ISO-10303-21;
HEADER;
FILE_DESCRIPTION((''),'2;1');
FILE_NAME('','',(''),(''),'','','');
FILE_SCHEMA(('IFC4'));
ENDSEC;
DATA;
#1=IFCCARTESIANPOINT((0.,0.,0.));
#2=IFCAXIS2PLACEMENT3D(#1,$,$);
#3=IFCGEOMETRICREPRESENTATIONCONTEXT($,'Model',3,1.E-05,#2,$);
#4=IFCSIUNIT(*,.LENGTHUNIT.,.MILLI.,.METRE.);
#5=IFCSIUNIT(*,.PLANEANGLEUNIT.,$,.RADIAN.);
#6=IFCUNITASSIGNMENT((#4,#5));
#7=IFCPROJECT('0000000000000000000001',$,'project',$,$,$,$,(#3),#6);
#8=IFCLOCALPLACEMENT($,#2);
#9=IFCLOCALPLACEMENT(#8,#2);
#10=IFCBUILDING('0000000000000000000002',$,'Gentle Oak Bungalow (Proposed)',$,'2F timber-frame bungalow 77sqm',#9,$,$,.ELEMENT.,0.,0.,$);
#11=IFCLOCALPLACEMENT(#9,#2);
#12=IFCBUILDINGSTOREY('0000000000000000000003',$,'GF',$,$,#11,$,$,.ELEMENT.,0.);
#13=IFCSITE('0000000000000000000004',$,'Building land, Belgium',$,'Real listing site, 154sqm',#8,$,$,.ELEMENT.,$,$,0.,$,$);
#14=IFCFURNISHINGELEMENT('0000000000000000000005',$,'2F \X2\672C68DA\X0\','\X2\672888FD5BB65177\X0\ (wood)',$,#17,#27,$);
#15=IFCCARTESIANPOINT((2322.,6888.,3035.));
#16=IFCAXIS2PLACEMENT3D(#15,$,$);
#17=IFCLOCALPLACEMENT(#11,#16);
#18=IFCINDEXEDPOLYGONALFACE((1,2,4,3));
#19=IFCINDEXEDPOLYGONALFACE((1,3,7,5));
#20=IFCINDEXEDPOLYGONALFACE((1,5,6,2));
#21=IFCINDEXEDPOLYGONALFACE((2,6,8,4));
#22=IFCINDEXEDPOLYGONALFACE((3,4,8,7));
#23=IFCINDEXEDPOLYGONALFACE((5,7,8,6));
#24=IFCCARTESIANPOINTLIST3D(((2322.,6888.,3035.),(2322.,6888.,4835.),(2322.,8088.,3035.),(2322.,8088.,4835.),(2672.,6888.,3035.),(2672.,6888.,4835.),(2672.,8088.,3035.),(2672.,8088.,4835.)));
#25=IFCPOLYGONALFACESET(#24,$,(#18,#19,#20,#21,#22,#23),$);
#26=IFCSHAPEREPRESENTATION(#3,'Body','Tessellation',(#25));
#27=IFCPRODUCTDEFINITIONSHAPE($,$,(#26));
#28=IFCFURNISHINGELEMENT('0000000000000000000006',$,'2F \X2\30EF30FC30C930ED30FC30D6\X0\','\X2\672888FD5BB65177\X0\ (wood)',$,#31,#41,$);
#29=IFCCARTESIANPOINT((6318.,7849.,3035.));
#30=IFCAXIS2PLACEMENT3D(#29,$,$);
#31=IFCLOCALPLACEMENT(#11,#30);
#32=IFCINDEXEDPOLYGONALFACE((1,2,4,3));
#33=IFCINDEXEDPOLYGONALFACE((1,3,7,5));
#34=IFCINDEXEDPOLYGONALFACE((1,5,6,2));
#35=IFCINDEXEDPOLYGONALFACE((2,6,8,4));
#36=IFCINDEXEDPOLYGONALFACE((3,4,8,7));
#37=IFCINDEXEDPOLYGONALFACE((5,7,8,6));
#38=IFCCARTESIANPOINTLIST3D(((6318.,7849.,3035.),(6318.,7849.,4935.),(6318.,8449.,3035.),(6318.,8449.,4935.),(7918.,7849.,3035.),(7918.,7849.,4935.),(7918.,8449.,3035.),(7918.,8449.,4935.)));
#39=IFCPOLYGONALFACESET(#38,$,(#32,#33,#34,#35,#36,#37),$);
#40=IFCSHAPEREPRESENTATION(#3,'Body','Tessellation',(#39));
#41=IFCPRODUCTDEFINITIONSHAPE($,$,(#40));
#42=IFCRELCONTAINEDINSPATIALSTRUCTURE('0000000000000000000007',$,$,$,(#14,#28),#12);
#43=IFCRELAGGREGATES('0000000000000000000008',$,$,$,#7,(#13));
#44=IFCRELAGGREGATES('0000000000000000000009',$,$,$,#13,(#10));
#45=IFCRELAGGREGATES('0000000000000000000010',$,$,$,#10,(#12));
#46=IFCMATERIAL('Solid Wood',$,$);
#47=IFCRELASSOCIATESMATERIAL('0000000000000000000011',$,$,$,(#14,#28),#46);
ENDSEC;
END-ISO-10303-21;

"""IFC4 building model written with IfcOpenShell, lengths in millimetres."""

from ifc_helpers import new_model, si_unit, frame, frame_2d, origin, place, context, project, spatial, rectangle, extrude, material, element, save


model = new_model("IFC4")

# Units and contexts
model_context = context("Model", 3, precision=1e-05, world=origin())
ifc_project = project(units=[si_unit("LENGTHUNIT", "METRE", prefix="MILLI"), si_unit("PLANEANGLEUNIT", "RADIAN")], contexts=[model_context])

# Site, building, storey
site_placement = place(None, origin())
site = spatial("IfcSite", under=ifc_project, at=site_placement, Name="Building land, Belgium", ObjectType="Real listing site, 154sqm", CompositionType="ELEMENT", RefElevation=0.0)
building_placement = place(site_placement, origin())
building = spatial("IfcBuilding", under=site, at=building_placement, Name="Gentle Oak Bungalow (Proposed)", ObjectType="2F timber-frame bungalow 77sqm", CompositionType="ELEMENT", ElevationOfRefHeight=0.0, ElevationOfTerrain=0.0)
storey_placement = place(building_placement, origin())
storey = spatial("IfcBuildingStorey", under=building, at=storey_placement, Name="GF", CompositionType="ELEMENT", Elevation=0.0)

# Shared definitions
ifc_material_1 = material(Name="Solid Wood")

# Furnishing elements
furnishing_1_placement = place(storey_placement, frame((2322.0, 6888.0, 3035.0)))
element("IfcFurnishingElement", 1, at=furnishing_1_placement, inside=storey, material=ifc_material_1, Name="2F 本棚", Description="木製家具 (wood)", context=model_context, shape_type="SweptSolid", body=[
    extrude(rectangle(XDim=350.0, YDim=1200.0, at=frame_2d((175.0, 600.0))), frame((2322.0, 6888.0, 3035.0)), (0.0, 0.0, 1.0), 1800.0),
])
furnishing_2_placement = place(storey_placement, frame((6318.0, 7849.0, 3035.0)))
element("IfcFurnishingElement", 2, at=furnishing_2_placement, inside=storey, material=ifc_material_1, Name="2F ワードローブ", Description="木製家具 (wood)", context=model_context, shape_type="SweptSolid", body=[
    extrude(rectangle(XDim=1600.0, YDim=600.0, at=frame_2d((800.0, 300.0))), frame((6318.0, 7849.0, 3035.0)), (0.0, 0.0, 1.0), 1900.0),
])

save(model, "model.ifc")
